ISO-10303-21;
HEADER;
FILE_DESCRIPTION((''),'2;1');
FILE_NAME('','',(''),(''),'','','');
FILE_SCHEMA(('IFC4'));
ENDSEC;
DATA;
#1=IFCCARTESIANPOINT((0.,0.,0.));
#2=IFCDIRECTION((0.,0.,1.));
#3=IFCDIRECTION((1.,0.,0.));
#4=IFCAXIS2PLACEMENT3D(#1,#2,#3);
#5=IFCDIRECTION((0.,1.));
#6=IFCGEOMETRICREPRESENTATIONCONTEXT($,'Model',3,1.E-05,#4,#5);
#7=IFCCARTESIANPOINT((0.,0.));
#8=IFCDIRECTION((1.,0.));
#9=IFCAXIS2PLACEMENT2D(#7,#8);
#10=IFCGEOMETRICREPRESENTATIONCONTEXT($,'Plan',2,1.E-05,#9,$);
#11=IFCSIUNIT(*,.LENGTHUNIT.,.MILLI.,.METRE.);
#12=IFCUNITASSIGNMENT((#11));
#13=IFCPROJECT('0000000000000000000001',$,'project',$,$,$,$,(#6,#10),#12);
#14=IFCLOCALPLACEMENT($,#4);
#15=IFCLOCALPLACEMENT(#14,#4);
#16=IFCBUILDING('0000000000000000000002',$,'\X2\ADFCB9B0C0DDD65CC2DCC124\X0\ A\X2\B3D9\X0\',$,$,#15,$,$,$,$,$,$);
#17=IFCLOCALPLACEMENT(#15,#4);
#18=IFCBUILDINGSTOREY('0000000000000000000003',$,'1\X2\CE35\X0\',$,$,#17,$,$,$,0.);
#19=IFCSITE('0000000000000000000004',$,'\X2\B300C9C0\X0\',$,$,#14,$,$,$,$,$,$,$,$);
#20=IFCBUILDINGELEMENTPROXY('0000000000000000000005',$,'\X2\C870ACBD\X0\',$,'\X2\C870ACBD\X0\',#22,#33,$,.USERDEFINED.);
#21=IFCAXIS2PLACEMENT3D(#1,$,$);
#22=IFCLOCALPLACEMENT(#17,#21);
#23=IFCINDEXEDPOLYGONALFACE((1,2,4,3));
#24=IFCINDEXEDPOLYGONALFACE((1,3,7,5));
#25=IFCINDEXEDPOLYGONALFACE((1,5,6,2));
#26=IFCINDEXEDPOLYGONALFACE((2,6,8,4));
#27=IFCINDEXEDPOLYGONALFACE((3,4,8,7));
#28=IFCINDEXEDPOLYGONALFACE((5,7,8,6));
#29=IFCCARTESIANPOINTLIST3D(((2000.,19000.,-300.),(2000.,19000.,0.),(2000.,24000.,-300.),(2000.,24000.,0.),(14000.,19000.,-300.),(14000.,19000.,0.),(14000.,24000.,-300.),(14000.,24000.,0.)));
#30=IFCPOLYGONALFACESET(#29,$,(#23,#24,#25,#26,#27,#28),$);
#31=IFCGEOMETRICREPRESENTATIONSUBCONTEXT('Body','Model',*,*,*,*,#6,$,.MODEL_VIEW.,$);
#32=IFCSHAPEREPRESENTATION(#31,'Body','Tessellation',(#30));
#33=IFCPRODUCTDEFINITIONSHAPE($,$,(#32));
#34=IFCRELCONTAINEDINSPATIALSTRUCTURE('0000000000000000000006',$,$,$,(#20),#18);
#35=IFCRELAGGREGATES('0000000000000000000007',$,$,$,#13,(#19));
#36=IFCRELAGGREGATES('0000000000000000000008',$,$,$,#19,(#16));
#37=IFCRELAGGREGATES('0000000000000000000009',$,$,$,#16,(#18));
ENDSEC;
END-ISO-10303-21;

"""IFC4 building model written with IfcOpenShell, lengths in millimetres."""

from ifc_helpers import new_model, si_unit, direction, frame, origin_with_axes, origin_2d_with_axis, place, context, subcontext, project, spatial, polyline, outline, extrude, element, save


model = new_model("IFC4")

# Units and contexts
model_context = context("Model", 3, precision=1e-05, world=origin_with_axes(), true_north=direction((0.0, 1.0)))
plan_context = context("Plan", 2, precision=1e-05, world=origin_2d_with_axis())
body_context = subcontext(model_context, "Body", "Model", "MODEL_VIEW")
ifc_project = project(units=[si_unit("LENGTHUNIT", "METRE", prefix="MILLI")], contexts=[model_context, plan_context])

# Site, building, storey
site_placement = place(None, origin_with_axes())
site = spatial("IfcSite", under=ifc_project, at=site_placement, Name="대지")
building_placement = place(site_placement, origin_with_axes())
building = spatial("IfcBuilding", under=site, at=building_placement, Name="근린생활시설 A동")
storey_placement = place(building_placement, origin_with_axes())
storey = spatial("IfcBuildingStorey", under=building, at=storey_placement, Name="1층", Elevation=0.0)

# Building element proxy
proxy_1_placement = place(storey_placement, origin_with_axes())
element("IfcBuildingElementProxy", 1, at=proxy_1_placement, inside=storey, Name="조경", ObjectType="조경", PredefinedType="USERDEFINED", context=body_context, shape_type="SweptSolid", body=[
    extrude(outline(polyline([(2000.0, 19000.0), (14000.0, 19000.0), (14000.0, 24000.0), (2000.0, 24000.0), (2000.0, 19000.0)])), frame((0.0, 0.0, -300.0), z_axis=(0.0, 0.0, 1.0), x_axis=(1.0, 0.0, 0.0)), (0.0, 0.0, 1.0), 300.0),
])

save(model, "model.ifc")
